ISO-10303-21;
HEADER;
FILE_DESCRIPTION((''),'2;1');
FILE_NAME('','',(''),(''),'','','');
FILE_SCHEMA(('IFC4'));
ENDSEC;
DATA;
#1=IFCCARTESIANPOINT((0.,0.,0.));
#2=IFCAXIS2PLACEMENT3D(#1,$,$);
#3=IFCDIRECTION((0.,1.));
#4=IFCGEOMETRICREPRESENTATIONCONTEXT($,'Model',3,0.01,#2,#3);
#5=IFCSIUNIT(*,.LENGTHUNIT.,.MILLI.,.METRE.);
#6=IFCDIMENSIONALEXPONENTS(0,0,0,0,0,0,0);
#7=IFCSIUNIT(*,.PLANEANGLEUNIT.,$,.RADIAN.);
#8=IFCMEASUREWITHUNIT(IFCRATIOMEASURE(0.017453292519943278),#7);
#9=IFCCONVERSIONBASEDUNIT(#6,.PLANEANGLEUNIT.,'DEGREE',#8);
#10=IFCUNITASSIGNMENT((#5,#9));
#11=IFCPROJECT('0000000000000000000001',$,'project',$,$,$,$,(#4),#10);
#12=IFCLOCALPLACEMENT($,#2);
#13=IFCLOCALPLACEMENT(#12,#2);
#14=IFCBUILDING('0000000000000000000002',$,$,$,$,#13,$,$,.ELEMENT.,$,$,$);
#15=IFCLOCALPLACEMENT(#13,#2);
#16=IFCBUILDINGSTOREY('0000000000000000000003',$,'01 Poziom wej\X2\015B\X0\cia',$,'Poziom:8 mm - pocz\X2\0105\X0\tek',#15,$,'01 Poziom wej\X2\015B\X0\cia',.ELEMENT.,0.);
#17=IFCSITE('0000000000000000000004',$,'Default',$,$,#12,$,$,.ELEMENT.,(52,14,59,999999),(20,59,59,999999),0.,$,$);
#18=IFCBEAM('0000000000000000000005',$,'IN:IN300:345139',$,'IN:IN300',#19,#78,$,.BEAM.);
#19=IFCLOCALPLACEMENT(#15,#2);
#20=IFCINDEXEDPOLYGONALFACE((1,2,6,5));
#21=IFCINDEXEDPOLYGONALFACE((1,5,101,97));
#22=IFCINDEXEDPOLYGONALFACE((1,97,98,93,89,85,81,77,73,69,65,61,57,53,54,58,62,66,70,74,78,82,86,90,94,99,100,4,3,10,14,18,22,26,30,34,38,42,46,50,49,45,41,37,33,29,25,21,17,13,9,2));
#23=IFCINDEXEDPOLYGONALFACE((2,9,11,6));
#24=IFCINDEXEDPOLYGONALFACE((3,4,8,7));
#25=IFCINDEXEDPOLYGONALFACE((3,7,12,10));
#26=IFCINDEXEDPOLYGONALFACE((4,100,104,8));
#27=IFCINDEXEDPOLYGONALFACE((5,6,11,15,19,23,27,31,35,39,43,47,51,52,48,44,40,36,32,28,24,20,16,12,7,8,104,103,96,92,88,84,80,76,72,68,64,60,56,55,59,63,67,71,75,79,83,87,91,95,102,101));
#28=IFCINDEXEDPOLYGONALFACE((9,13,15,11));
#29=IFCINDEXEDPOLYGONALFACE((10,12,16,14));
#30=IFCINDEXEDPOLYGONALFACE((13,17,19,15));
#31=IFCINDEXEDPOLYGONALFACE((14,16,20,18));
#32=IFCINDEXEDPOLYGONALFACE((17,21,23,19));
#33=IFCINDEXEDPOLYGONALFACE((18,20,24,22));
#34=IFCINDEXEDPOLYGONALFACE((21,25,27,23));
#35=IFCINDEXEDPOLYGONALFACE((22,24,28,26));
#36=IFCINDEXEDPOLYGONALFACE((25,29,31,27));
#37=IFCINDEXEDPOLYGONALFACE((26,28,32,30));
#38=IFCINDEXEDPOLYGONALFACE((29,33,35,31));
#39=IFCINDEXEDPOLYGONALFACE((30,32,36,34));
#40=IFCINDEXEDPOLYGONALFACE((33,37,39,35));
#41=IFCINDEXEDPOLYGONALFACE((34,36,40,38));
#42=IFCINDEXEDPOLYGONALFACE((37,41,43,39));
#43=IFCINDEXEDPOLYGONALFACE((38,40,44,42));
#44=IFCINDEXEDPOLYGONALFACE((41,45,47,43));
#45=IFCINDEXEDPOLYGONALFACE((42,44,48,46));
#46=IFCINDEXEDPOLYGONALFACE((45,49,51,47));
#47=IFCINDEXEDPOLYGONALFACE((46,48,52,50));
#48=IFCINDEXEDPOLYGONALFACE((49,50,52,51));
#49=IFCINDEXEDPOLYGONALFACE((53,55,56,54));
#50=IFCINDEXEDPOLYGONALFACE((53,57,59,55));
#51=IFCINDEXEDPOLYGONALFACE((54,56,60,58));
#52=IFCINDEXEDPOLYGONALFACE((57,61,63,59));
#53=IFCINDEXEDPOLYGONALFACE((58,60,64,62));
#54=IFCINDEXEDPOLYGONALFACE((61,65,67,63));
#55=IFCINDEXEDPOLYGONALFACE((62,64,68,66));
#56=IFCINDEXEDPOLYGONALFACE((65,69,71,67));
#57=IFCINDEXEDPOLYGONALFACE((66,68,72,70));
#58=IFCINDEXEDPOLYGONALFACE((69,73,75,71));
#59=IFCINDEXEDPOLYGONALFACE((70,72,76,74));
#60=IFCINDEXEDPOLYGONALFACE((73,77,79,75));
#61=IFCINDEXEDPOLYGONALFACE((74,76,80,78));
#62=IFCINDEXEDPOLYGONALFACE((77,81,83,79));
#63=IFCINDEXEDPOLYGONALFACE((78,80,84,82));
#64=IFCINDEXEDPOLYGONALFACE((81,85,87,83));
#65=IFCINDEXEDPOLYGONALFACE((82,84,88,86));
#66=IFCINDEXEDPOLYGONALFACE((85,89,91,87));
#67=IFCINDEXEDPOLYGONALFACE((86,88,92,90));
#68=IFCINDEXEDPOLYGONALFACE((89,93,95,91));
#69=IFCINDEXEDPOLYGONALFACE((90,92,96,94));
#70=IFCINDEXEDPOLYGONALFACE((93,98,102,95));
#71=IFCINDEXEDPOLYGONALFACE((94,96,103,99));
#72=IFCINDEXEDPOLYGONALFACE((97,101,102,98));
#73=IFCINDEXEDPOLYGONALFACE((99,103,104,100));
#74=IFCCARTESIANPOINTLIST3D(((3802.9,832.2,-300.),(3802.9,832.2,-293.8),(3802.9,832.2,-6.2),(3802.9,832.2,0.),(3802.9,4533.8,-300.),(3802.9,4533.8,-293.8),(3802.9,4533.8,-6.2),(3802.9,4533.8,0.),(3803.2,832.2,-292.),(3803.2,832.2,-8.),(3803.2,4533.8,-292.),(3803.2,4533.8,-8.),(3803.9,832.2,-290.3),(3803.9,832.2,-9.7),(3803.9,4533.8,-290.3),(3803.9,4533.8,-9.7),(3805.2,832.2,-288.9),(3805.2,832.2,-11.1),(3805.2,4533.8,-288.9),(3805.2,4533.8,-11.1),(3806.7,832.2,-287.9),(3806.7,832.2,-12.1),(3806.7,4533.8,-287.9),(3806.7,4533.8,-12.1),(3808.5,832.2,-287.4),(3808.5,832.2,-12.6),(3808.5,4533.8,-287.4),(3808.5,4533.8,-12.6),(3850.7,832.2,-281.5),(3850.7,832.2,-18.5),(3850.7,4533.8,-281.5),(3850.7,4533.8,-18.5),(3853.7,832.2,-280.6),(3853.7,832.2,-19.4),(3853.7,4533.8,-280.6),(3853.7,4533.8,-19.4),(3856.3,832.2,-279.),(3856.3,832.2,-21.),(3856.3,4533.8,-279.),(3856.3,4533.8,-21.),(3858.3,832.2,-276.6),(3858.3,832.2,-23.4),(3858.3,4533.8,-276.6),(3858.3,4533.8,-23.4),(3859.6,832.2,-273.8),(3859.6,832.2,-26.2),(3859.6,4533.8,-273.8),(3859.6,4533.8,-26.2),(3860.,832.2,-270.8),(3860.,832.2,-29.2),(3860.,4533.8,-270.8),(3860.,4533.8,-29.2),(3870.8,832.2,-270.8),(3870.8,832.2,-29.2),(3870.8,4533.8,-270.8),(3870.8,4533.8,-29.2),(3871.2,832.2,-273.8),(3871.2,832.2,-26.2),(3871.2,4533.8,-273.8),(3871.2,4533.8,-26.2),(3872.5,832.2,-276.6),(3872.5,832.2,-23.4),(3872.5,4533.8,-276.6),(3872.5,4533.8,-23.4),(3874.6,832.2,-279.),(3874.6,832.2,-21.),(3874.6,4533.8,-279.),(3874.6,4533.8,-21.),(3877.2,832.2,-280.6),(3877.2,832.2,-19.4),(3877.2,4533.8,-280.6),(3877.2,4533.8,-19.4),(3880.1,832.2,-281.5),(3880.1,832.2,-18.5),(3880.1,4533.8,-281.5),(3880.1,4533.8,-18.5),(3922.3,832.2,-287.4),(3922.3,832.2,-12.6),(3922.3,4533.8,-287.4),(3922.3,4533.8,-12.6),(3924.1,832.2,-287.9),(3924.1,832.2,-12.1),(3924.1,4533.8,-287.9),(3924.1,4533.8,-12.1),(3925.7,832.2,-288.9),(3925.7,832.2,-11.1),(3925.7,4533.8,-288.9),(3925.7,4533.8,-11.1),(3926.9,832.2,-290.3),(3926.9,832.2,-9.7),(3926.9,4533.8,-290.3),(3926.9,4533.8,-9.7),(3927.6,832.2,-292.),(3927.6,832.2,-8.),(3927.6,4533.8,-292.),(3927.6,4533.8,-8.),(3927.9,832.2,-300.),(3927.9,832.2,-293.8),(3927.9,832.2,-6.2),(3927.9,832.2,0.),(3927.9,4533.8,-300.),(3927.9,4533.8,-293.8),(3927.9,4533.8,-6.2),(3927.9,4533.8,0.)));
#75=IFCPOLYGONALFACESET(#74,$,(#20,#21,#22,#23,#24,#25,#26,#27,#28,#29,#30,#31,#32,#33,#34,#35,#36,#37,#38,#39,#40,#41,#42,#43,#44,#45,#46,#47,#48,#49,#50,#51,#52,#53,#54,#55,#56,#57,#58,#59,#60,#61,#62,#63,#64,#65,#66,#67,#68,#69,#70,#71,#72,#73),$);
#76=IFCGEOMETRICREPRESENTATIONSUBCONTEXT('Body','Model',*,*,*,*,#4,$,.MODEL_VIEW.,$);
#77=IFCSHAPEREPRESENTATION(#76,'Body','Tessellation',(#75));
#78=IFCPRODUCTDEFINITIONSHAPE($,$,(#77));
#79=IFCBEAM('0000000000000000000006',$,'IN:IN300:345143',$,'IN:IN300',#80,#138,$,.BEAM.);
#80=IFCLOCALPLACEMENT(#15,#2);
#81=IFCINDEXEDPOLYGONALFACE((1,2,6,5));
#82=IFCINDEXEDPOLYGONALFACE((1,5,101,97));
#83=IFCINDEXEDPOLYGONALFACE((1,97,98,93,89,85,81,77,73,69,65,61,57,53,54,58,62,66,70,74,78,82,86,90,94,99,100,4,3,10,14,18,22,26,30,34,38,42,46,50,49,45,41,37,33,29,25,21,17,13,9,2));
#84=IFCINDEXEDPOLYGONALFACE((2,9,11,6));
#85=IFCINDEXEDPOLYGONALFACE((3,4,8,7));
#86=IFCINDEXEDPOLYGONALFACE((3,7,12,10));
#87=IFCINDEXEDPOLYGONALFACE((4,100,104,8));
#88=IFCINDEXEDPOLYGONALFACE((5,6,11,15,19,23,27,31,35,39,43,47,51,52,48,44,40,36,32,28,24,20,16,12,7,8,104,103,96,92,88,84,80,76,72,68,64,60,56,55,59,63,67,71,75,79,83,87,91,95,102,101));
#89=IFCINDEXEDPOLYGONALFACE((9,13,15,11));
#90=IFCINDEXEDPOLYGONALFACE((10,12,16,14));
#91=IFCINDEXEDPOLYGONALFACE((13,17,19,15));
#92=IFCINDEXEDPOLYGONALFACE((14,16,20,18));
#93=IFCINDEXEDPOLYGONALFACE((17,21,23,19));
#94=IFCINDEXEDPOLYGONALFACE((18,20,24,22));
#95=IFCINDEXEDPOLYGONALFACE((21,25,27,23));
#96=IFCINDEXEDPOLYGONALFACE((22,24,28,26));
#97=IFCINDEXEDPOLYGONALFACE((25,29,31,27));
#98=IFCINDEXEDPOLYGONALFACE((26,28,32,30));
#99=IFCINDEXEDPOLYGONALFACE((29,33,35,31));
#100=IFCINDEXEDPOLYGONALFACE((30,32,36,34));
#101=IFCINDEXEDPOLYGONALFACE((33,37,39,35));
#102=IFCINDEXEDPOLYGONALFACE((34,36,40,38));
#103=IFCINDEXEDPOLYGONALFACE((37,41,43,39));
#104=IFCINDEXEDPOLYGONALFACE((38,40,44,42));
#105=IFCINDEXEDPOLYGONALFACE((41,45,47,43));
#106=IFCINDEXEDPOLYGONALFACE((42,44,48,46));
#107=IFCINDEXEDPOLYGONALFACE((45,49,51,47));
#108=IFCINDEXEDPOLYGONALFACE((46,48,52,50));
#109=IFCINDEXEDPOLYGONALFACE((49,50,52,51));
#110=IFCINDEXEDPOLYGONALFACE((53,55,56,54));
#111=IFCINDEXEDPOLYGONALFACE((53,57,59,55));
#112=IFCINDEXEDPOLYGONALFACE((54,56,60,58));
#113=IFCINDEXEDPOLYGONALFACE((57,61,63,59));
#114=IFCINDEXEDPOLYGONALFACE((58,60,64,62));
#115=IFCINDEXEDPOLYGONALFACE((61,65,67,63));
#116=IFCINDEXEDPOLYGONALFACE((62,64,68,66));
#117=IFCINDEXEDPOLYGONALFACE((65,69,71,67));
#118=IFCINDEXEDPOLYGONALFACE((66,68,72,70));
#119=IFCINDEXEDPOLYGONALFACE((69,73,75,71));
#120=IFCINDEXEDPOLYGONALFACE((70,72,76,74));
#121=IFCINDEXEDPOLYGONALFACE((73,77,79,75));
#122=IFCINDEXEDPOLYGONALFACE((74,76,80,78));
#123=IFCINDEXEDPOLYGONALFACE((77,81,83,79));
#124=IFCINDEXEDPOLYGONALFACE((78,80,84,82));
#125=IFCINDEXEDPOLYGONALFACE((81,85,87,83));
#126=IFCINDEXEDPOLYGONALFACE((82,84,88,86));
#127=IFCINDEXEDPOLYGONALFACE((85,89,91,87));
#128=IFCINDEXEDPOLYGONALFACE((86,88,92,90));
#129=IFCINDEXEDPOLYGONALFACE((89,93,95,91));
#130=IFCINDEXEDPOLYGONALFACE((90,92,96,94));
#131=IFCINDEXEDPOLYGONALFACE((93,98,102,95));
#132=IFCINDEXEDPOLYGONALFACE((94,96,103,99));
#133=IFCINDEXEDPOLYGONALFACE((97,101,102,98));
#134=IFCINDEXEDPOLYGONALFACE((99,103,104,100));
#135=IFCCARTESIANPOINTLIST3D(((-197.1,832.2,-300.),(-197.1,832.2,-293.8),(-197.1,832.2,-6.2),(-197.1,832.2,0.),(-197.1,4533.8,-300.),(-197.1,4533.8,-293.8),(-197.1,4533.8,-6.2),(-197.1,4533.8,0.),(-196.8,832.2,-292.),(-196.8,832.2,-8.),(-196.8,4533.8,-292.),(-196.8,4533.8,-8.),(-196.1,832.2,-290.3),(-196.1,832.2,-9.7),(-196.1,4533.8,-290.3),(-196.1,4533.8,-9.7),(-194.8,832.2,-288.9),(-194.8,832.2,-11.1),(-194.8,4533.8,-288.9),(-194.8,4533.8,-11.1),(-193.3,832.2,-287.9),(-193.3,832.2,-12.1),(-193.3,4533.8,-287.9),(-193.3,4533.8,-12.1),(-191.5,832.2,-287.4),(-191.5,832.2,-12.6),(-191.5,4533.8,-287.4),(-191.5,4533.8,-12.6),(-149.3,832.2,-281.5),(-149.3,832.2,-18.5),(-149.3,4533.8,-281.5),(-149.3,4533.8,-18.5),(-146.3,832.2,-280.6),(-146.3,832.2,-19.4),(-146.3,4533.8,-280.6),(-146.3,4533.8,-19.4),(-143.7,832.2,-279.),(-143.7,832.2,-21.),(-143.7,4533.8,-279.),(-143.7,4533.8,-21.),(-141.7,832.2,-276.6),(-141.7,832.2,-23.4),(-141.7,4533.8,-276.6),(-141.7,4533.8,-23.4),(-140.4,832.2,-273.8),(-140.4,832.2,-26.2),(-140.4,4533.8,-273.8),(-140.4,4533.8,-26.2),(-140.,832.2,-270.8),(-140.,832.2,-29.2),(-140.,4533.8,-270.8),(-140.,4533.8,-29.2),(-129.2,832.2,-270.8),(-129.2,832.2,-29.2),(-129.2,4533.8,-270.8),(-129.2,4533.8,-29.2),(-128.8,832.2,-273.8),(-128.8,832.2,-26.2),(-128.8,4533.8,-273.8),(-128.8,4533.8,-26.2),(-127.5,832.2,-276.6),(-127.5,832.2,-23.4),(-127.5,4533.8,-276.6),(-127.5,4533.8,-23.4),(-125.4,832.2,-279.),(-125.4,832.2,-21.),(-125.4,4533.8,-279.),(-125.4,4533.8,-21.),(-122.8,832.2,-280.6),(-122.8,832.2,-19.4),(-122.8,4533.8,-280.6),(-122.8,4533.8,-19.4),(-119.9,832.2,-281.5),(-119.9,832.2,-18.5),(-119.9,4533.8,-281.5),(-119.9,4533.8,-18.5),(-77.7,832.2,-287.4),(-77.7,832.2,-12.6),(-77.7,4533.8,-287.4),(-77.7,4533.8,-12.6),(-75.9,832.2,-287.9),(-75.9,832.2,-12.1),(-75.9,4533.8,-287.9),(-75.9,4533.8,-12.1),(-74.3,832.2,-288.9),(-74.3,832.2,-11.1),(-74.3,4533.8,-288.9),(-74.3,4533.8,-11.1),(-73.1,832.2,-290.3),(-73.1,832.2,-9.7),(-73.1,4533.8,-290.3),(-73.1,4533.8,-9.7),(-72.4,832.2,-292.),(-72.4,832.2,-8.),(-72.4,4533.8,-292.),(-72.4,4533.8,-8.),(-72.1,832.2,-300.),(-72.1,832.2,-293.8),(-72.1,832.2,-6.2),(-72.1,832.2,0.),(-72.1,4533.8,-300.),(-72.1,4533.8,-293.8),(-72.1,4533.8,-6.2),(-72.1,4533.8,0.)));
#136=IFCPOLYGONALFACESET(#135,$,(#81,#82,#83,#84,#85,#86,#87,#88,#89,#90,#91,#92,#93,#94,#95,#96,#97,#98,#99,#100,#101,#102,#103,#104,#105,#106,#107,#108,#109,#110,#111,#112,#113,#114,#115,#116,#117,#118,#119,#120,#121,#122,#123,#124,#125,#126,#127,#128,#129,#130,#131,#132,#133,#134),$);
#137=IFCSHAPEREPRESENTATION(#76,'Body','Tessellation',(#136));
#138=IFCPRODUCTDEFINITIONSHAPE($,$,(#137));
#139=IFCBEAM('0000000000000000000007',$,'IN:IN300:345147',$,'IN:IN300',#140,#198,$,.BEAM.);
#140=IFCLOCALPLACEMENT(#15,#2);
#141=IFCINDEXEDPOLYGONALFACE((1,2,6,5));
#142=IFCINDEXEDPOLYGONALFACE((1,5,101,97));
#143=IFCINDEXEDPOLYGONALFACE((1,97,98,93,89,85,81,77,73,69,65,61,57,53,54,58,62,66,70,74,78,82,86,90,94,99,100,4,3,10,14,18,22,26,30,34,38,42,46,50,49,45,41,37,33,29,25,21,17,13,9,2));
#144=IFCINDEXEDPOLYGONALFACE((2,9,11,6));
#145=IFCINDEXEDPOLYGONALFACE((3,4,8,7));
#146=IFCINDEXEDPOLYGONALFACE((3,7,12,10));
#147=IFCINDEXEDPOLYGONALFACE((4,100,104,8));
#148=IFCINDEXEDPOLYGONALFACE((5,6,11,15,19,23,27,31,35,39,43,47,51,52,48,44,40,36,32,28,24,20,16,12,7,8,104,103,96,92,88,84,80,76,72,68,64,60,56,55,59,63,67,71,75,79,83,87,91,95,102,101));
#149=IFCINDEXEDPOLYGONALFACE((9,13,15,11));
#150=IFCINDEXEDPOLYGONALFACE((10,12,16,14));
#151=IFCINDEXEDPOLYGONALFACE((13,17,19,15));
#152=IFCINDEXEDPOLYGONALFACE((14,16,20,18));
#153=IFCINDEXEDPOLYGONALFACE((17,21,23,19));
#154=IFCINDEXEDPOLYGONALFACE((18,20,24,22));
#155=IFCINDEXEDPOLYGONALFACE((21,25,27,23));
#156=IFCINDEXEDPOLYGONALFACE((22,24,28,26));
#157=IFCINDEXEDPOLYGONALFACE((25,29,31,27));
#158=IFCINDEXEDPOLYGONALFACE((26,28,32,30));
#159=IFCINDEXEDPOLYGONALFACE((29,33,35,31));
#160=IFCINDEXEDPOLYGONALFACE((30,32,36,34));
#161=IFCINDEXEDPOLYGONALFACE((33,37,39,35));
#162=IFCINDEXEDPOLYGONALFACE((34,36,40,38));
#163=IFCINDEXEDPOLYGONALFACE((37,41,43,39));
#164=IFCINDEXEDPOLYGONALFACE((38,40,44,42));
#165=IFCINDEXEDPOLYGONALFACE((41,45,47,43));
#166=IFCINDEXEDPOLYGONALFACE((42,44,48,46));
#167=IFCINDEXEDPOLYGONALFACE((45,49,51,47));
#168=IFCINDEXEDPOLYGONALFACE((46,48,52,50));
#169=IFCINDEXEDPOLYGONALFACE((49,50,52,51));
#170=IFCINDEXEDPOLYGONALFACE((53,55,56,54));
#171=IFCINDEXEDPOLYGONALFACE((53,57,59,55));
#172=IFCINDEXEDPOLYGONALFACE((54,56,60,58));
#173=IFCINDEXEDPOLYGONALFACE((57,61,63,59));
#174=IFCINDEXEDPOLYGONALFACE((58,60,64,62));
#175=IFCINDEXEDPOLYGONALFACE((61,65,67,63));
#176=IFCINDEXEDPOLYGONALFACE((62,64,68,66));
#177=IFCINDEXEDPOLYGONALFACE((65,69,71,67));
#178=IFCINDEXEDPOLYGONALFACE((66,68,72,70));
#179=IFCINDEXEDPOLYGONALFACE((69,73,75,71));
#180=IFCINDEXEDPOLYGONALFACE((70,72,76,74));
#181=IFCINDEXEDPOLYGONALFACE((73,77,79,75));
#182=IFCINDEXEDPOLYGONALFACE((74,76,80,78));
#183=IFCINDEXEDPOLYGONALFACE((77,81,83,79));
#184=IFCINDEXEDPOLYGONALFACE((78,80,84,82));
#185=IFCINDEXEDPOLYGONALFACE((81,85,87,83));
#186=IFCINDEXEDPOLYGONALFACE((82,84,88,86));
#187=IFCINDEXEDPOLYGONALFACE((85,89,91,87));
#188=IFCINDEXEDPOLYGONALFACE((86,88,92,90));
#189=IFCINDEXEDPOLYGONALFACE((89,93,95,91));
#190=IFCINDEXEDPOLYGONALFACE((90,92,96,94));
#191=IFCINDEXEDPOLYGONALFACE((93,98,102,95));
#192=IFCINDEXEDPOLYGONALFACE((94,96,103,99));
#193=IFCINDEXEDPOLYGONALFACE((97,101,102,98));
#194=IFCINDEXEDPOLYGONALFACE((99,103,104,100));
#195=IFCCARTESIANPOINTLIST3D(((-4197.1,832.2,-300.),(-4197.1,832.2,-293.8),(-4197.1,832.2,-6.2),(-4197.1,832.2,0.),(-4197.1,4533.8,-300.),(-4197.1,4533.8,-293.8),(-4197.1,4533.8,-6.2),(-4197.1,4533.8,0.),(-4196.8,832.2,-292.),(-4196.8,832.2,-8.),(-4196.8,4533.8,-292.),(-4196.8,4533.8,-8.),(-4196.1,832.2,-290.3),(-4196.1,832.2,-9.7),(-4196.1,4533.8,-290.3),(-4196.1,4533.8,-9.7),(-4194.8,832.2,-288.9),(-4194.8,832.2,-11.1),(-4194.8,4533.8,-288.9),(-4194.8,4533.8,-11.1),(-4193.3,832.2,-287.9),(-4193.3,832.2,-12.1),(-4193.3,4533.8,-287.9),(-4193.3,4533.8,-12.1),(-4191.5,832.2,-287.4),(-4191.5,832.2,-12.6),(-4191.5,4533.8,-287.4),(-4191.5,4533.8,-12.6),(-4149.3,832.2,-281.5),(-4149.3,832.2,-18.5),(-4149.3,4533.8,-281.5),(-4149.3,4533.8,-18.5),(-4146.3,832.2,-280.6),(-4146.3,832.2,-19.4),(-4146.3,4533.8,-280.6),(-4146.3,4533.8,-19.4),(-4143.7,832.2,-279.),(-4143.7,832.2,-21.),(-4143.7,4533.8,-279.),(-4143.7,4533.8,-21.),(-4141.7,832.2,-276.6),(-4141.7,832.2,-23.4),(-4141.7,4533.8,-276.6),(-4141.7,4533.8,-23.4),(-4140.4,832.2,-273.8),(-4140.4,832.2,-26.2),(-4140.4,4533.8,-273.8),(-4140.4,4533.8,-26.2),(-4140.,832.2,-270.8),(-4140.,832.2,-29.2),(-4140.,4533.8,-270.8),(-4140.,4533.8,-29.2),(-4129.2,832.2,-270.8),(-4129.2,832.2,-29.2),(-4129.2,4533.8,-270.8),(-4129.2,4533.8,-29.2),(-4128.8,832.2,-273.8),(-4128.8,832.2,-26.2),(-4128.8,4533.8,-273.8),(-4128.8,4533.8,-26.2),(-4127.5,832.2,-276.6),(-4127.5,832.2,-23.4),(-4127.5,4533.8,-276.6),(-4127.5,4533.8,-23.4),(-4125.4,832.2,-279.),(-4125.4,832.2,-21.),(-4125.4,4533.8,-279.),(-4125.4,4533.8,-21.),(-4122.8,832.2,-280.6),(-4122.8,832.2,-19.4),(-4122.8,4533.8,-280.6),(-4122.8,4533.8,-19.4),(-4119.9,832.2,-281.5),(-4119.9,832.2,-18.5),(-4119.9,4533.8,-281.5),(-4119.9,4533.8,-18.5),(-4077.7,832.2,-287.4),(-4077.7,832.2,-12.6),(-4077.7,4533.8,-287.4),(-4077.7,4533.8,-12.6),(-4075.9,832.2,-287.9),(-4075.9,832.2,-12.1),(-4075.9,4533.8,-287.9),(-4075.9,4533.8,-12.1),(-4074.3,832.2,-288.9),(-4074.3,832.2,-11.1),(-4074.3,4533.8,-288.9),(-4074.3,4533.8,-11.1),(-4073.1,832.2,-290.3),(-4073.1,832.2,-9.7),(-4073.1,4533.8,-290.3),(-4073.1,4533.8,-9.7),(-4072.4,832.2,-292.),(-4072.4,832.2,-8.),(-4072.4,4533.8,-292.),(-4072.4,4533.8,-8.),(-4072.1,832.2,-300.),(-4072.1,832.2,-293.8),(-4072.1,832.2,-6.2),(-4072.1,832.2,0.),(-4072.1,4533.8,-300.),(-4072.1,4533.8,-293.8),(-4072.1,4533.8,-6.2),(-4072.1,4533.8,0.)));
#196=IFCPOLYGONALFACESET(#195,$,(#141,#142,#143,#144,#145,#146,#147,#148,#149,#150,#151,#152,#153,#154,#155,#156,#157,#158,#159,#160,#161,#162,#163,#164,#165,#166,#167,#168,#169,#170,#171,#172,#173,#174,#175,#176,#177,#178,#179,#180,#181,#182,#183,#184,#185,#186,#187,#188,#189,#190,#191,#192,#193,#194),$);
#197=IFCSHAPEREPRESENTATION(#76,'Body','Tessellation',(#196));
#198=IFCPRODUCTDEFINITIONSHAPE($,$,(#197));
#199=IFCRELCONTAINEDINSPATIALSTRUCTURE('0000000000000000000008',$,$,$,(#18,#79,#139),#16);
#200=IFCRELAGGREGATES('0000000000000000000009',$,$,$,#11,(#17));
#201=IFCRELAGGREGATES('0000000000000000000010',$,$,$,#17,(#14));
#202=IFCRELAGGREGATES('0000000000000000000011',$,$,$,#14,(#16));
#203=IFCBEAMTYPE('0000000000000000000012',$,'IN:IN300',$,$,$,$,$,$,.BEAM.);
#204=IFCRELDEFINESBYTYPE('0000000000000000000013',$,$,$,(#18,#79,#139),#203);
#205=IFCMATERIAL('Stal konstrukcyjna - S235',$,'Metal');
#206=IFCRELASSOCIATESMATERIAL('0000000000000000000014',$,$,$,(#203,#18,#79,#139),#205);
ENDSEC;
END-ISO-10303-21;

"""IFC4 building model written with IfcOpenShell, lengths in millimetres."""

from ifc_helpers import new_model, entity, si_unit, converted_unit, direction, frame, origin, place, context, subcontext, project, spatial, line, arc, indexed_curve, outline, extrude, source, transform, mapped, material, type_object, type_shapes, element, save


model = new_model("IFC4")

# Units and contexts
model_context = context("Model", 3, precision=0.01, world=origin(), true_north=direction((0.0, 1.0)))
body_context = subcontext(model_context, "Body", "Model", "MODEL_VIEW")
ifc_project = project(units=[si_unit("LENGTHUNIT", "METRE", prefix="MILLI"), converted_unit("PLANEANGLEUNIT", "DEGREE", entity("IfcRatioMeasure", 0.017453292519943278), si_unit("PLANEANGLEUNIT", "RADIAN"), dimensions=[0, 0, 0, 0, 0, 0, 0])], contexts=[model_context])

# Site, building, storey
site_placement = place(None, origin())
site = spatial("IfcSite", under=ifc_project, at=site_placement, Name="Default", CompositionType="ELEMENT", RefLatitude=(52, 14, 59, 999999), RefLongitude=(20, 59, 59, 999999), RefElevation=0.0)
building_placement = place(site_placement, origin())
building = spatial("IfcBuilding", under=site, at=building_placement, CompositionType="ELEMENT")
storey_placement = place(building_placement, origin())
storey = spatial("IfcBuildingStorey", under=building, at=storey_placement, Name="01 Poziom wejścia", ObjectType="Poziom:8 mm - początek", LongName="01 Poziom wejścia", CompositionType="ELEMENT", Elevation=0.0)

# Beams
ifc_material = material(Name="Stal konstrukcyjna - S235", Category="Metal")
beam_type_1 = type_object("IfcBeamType", Name="IN:IN300", PredefinedType="BEAM", material=ifc_material)
shared_shape_1 = source(origin(), body_context, "Body", "SweptSolid", [
    extrude(outline(indexed_curve([(143.8, -62.5), (150.0, -62.5), (150.0, 62.5), (143.8, 62.5), (139.6, 60.9), (137.4, 56.9), (131.5, 14.7), (127.9, 8.1), (120.8, 5.4), (-120.8, 5.4), (-127.9, 8.1), (-131.5, 14.7), (-137.4, 56.9), (-139.6, 60.9), (-143.8, 62.5), (-150.0, 62.5), (-150.0, -62.5), (-143.8, -62.5), (-139.6, -60.9), (-137.4, -56.9), (-131.5, -14.7), (-127.9, -8.1), (-120.8, -5.4), (120.8, -5.4), (127.9, -8.1), (131.5, -14.7), (137.4, -56.9), (139.6, -60.9)], segments=[line(1, 2, 3, 4), arc(4, 5, 6), line(6, 7), arc(7, 8, 9), line(9, 10), arc(10, 11, 12), line(12, 13), arc(13, 14, 15), line(15, 16, 17, 18), arc(18, 19, 20), line(20, 21), arc(21, 22, 23), line(23, 24), arc(24, 25, 26), line(26, 27), arc(27, 28, 1)], self_intersect=False)), frame((-1850.8, 0.0, 0.0), z_axis=(1.0, 0.0, 0.0), x_axis=(0.0, 0.0, -1.0)), (0.0, 0.0, 1.0), 3701.6),
])
type_shapes(beam_type_1, [shared_shape_1])
for number, where, z_axis, x_axis, name in (
    (1, (3865.4, 2683.0, -150.0), (0.0, 0.0, 1.0), (0.0, -1.0, 0.0), "IN:IN300:345139"),
    (2, (-134.6, 2683.0, -150.0), (0.0, 0.0, 1.0), (0.0, -1.0, 0.0), "IN:IN300:345143"),
    (3, (-4134.6, 2683.0, -150.0), (0.0, 0.0, 1.0), (0.0, -1.0, 0.0), "IN:IN300:345147"),
):
    element("IfcBeam", number, at=place(storey_placement, frame(where, z_axis=z_axis, x_axis=x_axis)), inside=storey, type_object=beam_type_1, material=ifc_material, Name=name, ObjectType="IN:IN300", PredefinedType="BEAM", context=body_context, shape_type="MappedRepresentation", body=[
        mapped(shared_shape_1, transform((0.0, 0.0, 0.0), scale=1.0)),
    ])

save(model, "model.ifc")
